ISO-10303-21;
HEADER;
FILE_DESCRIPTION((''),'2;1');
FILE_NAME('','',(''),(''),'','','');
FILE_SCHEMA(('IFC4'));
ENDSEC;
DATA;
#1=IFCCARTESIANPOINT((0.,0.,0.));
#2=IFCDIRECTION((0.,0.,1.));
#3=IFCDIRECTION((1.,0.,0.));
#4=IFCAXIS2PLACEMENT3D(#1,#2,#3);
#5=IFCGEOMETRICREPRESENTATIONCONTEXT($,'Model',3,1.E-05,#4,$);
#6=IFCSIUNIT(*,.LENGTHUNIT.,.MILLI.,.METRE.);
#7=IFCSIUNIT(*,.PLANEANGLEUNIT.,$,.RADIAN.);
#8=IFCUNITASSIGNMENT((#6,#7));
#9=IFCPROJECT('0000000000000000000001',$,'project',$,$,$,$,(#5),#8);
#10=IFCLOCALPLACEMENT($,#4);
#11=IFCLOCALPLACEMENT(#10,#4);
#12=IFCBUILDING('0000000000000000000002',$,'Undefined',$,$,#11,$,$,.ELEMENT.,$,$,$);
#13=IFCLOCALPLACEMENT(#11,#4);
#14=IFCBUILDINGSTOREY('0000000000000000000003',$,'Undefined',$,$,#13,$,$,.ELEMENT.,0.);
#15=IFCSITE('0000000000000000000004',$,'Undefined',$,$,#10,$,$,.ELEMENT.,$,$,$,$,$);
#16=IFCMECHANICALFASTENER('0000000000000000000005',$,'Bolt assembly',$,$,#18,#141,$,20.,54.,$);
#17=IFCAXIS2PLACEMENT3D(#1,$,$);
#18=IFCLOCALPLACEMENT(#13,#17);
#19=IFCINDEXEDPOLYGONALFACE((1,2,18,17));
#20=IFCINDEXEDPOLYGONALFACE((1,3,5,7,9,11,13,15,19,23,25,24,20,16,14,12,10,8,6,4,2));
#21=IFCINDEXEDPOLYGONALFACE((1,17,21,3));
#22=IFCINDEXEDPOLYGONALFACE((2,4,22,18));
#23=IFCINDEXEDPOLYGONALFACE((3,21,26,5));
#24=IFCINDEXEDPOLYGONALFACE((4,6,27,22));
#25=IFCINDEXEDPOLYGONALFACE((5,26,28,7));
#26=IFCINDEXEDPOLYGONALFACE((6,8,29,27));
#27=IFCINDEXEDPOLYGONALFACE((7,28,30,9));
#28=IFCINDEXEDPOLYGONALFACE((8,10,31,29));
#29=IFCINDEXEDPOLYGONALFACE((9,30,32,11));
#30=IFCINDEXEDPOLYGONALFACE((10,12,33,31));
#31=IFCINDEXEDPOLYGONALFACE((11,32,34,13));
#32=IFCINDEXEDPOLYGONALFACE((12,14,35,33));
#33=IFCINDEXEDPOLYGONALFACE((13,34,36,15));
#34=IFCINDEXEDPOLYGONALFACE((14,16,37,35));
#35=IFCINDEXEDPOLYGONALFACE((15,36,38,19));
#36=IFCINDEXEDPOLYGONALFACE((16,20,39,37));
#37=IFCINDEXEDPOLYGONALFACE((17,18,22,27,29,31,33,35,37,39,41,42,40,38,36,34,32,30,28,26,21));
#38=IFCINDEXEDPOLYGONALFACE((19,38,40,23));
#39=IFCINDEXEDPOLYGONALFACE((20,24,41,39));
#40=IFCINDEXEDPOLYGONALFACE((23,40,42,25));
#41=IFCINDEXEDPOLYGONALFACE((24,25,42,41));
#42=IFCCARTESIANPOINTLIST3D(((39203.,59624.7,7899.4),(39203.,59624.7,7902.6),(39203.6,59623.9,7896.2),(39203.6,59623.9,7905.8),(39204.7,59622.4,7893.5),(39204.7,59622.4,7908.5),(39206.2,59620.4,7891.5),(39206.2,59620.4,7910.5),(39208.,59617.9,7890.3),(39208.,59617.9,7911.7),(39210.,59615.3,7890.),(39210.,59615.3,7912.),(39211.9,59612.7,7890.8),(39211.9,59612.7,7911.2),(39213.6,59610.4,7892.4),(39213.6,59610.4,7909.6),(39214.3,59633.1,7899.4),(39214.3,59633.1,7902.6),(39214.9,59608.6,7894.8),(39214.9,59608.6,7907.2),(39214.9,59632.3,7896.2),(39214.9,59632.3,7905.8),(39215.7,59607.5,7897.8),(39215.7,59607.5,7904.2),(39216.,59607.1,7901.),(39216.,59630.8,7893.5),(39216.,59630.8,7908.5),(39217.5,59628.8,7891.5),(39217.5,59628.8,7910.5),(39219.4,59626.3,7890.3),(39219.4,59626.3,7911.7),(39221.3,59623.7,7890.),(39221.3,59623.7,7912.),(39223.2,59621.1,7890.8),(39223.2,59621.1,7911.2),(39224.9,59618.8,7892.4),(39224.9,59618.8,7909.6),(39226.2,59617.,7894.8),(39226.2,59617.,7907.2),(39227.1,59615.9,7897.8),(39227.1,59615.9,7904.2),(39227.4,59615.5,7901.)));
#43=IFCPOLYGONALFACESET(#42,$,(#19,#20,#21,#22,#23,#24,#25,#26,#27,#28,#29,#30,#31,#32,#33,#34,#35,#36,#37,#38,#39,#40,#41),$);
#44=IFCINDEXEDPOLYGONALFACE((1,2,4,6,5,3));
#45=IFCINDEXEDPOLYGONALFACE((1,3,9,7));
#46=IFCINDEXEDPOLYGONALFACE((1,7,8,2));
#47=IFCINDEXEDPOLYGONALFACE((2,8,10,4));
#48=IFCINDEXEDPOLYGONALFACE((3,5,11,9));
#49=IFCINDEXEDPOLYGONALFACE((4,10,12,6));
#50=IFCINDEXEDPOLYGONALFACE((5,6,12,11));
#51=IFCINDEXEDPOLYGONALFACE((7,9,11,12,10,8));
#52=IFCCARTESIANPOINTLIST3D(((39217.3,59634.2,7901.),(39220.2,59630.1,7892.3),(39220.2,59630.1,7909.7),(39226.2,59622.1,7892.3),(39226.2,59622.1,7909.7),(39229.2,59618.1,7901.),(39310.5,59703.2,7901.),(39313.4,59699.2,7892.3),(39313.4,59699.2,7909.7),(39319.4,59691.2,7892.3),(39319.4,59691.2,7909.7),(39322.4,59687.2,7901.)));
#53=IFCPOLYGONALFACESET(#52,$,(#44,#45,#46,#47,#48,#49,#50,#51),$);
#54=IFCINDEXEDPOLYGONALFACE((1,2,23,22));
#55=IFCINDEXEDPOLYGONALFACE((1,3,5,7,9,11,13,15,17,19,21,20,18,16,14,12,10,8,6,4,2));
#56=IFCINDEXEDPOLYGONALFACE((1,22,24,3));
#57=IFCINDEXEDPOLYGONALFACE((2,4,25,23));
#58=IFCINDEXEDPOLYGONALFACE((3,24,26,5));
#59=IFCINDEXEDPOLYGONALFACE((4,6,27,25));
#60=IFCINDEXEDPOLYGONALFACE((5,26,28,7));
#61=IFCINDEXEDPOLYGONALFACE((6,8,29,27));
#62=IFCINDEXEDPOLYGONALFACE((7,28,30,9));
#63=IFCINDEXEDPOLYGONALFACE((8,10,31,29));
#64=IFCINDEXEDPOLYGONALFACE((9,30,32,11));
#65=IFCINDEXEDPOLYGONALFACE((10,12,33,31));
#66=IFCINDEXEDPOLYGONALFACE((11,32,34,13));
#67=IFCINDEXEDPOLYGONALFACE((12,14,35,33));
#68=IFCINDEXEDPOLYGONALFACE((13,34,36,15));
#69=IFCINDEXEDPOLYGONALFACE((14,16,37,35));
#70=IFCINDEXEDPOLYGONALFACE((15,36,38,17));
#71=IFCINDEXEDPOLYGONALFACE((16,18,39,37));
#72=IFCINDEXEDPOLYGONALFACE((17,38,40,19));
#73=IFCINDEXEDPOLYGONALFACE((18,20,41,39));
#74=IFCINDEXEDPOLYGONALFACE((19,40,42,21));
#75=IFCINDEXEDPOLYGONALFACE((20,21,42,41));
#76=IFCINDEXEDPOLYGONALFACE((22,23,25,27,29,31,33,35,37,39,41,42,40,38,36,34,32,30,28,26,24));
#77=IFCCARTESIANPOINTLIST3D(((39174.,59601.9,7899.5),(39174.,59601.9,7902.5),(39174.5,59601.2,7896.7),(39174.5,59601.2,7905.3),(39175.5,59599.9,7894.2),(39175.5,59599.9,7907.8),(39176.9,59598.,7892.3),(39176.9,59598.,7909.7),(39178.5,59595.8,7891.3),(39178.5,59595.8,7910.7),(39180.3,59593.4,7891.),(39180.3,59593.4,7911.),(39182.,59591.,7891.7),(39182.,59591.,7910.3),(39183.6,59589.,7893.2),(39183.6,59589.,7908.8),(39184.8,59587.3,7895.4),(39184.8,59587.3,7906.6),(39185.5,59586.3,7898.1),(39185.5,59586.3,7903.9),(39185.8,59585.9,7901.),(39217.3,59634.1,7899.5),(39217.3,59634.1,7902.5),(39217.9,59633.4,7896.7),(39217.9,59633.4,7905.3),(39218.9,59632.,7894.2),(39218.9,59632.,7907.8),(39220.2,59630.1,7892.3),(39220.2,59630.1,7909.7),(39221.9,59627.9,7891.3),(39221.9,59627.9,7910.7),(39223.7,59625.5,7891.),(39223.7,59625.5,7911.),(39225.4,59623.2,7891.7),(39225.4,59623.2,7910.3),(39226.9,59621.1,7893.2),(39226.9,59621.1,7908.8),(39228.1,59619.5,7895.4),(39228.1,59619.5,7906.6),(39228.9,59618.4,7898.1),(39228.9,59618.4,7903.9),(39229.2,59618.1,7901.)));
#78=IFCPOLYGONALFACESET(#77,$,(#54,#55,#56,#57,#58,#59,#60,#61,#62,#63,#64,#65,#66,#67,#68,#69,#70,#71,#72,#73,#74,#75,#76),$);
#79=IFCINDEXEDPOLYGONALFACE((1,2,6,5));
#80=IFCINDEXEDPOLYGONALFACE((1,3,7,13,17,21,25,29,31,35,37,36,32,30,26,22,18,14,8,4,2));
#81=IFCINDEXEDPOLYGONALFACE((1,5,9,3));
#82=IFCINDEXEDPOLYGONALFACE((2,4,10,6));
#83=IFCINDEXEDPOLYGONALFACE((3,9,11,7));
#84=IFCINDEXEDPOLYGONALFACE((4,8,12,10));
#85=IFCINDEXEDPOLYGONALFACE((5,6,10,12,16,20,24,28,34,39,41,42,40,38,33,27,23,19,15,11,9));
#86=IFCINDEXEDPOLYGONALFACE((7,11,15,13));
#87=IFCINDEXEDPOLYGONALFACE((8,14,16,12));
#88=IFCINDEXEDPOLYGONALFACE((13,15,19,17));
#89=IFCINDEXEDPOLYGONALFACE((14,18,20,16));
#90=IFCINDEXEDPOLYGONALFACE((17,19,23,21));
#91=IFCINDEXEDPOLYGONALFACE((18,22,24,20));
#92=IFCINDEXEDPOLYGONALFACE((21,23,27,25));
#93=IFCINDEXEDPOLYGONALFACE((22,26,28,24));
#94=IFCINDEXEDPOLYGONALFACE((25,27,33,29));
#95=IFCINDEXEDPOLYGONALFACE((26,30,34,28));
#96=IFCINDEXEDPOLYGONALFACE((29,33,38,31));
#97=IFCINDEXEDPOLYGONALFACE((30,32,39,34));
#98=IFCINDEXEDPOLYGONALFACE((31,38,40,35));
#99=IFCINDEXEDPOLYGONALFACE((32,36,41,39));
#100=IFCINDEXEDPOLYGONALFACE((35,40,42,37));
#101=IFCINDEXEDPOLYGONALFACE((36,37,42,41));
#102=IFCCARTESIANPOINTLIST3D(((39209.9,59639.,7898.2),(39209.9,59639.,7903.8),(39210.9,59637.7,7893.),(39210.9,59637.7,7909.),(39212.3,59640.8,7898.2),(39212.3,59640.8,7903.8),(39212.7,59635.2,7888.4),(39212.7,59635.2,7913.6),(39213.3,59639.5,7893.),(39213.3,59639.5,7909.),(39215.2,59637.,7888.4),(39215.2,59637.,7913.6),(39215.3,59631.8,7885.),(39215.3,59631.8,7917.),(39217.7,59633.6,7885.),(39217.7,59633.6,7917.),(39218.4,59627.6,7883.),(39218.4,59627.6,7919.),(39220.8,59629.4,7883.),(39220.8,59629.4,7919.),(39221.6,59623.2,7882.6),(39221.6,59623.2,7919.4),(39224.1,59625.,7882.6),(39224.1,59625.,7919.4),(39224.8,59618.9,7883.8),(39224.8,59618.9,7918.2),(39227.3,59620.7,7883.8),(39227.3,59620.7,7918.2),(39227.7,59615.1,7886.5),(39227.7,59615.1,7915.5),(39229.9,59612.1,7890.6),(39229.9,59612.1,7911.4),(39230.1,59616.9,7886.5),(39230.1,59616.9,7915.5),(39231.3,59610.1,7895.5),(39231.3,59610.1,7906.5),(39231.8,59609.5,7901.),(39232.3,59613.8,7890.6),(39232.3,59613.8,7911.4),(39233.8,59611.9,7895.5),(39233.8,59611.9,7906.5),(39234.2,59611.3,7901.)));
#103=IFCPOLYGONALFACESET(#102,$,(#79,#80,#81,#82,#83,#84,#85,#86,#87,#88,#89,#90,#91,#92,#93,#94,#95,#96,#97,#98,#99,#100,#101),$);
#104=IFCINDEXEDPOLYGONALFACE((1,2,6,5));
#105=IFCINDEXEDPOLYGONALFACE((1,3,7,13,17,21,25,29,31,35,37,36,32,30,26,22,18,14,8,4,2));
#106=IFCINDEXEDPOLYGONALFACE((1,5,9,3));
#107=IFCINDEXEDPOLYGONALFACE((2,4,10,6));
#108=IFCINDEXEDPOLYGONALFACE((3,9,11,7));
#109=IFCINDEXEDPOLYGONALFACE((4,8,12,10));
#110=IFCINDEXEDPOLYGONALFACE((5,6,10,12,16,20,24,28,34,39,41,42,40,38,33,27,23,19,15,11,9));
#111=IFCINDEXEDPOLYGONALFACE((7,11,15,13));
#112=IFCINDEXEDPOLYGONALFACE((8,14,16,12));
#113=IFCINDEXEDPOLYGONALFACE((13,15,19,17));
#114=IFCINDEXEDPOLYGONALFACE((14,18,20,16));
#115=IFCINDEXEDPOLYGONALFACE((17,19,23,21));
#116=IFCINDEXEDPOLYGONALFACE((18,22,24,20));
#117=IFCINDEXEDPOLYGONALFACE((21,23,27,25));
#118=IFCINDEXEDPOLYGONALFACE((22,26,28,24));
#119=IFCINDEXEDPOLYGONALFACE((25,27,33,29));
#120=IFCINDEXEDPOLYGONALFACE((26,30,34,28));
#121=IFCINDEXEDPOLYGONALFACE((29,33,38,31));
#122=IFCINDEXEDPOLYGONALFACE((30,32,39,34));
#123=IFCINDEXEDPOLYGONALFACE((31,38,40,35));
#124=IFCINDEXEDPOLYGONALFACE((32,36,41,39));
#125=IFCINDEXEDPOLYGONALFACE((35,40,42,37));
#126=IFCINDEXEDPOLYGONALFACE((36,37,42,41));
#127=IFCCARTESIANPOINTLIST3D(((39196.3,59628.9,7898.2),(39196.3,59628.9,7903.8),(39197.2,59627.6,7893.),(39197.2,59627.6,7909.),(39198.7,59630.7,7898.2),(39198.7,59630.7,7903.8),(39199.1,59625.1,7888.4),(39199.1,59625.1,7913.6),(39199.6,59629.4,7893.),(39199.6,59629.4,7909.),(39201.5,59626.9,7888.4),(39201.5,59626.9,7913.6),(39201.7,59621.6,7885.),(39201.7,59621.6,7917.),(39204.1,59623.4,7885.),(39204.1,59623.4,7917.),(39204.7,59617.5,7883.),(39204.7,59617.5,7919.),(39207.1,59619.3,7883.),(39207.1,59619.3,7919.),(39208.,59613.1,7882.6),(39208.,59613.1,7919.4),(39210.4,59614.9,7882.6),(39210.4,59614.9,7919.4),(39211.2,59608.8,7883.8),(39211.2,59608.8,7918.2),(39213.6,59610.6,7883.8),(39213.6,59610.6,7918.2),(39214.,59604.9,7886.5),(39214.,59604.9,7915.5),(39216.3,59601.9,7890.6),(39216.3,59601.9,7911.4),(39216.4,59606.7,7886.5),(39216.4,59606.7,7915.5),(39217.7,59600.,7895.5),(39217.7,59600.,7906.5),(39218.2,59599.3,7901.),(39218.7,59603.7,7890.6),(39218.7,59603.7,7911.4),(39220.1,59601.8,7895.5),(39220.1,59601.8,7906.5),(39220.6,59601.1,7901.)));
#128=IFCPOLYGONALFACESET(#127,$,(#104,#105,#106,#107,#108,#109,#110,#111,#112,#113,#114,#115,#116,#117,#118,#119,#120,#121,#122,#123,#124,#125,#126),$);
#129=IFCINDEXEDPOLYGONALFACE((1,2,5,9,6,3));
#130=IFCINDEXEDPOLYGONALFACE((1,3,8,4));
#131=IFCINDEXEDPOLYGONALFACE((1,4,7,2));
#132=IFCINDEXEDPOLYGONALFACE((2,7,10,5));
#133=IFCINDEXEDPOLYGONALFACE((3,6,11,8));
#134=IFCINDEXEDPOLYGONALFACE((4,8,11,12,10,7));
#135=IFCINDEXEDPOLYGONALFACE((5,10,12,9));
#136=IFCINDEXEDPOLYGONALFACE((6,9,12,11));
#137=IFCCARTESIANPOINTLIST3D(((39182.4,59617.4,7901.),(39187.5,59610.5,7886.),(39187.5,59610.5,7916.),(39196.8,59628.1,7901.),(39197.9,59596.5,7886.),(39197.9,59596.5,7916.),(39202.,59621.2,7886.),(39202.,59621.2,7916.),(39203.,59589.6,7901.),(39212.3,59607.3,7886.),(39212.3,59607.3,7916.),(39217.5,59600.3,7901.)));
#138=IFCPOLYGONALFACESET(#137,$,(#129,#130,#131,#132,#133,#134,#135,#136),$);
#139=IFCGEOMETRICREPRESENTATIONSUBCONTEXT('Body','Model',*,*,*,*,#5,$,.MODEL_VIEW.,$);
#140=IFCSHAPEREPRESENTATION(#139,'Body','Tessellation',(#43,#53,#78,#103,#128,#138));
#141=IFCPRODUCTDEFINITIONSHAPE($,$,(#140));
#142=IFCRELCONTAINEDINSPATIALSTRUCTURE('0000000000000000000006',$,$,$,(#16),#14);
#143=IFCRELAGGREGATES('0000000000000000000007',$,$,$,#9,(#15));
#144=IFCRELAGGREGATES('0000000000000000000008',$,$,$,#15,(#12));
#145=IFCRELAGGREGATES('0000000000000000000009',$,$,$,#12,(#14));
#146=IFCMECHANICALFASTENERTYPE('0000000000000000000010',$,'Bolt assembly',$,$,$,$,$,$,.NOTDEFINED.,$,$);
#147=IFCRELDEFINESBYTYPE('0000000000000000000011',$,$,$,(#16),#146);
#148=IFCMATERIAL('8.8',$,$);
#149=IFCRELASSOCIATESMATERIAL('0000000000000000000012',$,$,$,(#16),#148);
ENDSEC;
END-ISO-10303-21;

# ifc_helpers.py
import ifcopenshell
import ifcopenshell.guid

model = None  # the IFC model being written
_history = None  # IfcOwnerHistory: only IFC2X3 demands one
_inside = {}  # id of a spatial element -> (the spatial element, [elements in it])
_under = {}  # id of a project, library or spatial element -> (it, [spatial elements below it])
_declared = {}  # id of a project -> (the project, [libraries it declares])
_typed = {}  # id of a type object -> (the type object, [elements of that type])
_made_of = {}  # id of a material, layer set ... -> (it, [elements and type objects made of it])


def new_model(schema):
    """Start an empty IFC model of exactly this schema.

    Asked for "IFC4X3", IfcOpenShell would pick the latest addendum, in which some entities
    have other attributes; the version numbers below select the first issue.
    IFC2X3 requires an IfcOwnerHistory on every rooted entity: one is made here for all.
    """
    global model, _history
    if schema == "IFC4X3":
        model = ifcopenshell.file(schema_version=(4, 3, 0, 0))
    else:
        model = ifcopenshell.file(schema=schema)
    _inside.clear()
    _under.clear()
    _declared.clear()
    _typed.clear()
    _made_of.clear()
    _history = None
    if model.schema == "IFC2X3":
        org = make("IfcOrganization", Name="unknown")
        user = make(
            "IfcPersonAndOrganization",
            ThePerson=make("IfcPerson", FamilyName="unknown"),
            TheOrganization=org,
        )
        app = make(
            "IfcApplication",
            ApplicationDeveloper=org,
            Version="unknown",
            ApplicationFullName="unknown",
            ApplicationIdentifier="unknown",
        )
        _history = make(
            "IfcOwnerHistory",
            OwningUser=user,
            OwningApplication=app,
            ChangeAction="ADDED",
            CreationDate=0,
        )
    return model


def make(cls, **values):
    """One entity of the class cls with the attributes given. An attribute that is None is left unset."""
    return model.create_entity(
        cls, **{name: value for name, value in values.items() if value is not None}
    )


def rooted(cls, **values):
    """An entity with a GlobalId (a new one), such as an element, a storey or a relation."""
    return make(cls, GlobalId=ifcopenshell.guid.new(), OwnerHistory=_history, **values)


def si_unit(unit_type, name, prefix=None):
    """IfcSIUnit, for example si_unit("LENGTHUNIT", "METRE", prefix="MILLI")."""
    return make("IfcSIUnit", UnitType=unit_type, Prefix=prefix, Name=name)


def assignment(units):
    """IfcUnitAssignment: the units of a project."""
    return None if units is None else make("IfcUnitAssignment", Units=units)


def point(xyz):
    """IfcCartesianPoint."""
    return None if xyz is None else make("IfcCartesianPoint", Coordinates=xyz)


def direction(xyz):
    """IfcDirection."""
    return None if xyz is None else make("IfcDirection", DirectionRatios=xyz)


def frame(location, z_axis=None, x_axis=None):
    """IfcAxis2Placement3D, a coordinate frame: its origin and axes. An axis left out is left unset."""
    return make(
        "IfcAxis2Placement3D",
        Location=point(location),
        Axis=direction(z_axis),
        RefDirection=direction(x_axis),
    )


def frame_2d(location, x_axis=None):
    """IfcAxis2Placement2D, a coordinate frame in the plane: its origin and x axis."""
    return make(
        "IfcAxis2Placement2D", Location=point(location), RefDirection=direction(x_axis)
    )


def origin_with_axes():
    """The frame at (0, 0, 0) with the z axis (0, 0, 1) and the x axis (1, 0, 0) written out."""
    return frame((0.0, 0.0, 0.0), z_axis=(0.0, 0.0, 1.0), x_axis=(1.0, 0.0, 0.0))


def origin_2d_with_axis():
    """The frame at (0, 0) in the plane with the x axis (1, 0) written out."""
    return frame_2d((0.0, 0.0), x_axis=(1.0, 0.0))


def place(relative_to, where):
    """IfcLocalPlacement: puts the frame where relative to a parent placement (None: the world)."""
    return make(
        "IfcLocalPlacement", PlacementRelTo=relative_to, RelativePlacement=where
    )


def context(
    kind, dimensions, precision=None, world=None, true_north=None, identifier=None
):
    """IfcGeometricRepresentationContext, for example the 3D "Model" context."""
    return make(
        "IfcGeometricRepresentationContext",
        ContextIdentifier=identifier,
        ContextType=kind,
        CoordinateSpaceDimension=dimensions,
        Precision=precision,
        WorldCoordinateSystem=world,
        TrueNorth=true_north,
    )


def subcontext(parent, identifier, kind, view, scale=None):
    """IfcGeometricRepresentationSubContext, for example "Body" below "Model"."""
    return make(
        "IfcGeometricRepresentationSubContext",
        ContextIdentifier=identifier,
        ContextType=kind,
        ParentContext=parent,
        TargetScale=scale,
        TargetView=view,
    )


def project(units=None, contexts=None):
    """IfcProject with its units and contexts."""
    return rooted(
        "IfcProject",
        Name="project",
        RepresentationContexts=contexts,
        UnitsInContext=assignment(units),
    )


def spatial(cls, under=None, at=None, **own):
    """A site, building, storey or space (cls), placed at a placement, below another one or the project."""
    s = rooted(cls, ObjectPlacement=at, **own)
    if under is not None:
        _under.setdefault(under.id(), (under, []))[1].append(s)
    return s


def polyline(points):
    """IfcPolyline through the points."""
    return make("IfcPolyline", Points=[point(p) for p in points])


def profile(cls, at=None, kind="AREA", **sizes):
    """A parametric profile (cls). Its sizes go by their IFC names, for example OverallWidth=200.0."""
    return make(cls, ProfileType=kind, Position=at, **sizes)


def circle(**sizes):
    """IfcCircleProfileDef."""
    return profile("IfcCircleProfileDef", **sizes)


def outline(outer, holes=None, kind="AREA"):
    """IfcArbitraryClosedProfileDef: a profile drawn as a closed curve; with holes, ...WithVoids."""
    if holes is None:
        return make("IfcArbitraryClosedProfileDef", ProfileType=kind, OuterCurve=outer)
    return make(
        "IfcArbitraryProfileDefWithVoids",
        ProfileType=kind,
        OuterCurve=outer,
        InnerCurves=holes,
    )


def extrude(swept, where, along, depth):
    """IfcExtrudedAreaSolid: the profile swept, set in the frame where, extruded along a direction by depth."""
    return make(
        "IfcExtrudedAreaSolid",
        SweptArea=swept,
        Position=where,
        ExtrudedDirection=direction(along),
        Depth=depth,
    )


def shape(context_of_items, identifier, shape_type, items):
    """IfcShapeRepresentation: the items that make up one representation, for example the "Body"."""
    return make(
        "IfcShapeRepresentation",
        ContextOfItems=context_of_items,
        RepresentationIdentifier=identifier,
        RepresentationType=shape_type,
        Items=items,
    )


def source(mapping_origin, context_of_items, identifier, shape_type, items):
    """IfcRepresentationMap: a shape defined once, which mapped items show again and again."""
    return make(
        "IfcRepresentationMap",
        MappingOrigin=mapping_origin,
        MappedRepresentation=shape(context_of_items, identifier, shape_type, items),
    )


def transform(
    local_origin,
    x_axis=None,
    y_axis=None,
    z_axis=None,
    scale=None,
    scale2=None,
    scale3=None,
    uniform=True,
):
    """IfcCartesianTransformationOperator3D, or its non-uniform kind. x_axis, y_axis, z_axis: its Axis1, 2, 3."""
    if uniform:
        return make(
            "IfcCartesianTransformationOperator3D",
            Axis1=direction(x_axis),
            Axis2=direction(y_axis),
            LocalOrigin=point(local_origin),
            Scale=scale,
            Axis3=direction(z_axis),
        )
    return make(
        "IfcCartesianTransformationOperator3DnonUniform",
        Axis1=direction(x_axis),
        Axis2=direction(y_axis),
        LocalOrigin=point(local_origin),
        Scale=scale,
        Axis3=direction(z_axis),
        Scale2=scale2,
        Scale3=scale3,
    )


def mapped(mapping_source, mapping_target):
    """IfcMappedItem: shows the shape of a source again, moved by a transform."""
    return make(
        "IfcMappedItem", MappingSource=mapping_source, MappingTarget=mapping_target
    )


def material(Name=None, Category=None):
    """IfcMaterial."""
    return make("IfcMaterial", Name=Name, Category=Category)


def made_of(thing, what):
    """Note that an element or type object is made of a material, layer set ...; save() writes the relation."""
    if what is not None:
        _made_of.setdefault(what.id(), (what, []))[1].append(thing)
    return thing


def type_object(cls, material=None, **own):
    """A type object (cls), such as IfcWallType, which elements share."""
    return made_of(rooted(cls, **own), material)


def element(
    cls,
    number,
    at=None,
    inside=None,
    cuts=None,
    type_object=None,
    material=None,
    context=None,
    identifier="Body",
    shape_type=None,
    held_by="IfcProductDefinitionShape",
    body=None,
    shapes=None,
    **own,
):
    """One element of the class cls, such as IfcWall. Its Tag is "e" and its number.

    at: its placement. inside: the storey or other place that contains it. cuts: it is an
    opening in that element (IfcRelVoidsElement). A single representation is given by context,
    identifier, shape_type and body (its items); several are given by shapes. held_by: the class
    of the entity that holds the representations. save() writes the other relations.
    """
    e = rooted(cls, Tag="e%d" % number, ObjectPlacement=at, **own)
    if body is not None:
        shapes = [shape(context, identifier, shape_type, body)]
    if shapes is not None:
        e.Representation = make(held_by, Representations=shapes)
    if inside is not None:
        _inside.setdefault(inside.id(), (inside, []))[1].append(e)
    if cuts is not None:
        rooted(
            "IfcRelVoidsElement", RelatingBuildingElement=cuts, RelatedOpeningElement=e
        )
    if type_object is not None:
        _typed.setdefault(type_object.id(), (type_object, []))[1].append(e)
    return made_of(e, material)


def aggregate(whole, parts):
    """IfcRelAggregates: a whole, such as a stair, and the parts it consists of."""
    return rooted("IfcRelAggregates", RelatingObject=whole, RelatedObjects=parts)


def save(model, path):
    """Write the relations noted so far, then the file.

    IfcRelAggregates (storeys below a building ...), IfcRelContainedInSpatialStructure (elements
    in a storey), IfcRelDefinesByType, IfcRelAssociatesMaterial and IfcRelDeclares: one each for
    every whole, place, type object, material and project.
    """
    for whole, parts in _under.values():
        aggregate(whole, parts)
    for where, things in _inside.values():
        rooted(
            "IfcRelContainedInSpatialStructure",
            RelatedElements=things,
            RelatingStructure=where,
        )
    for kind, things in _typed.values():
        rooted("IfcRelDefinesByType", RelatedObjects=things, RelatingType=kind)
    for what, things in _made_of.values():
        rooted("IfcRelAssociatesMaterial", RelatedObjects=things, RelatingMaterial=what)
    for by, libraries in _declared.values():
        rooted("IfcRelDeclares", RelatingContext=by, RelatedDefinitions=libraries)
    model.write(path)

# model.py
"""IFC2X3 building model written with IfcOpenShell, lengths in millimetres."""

from ifc_helpers import new_model, si_unit, frame, origin_with_axes, origin_2d_with_axis, place, context, subcontext, project, spatial, polyline, circle, outline, extrude, source, transform, mapped, material, type_object, element, save


model = new_model("IFC2X3")

# Units and contexts
model_context = context("Model", 3, precision=1e-05, world=origin_with_axes())
body_context = subcontext(model_context, "Body", "Model", "MODEL_VIEW")
ifc_project = project(units=[si_unit("LENGTHUNIT", "METRE", prefix="MILLI"), si_unit("PLANEANGLEUNIT", "RADIAN")], contexts=[model_context])

# Site, building, storey
site_placement = place(None, origin_with_axes())
site = spatial("IfcSite", under=ifc_project, at=site_placement, Name="Undefined", CompositionType="ELEMENT")
building_placement = place(site_placement, origin_with_axes())
building = spatial("IfcBuilding", under=site, at=building_placement, Name="Undefined", CompositionType="ELEMENT")
storey_placement = place(building_placement, origin_with_axes())
storey = spatial("IfcBuildingStorey", under=building, at=storey_placement, Name="Undefined", CompositionType="ELEMENT", Elevation=0.0)

# Mechanical fastener
ifc_material_1 = material(Name="8.8")
mechanical_fastener_type = type_object("IfcMechanicalFastenerType", Name="Bolt assembly")
shared_shape_1 = source(origin_with_axes(), body_context, "Body", "SweptSolid", [
    extrude(circle(Radius=11.0, at=origin_2d_with_axis()), frame((0.0, -14.0, 0.0), z_axis=(0.0, 1.0, 0.0), x_axis=(1.0, 0.0, 0.0)), (0.0, 0.0, 1.0), 14.1),
    extrude(outline(polyline([(10.0, 0.0), (5.0, 8.7), (-5.0, 8.7), (-10.0, 0.0), (-5.0, -8.7), (5.0, -8.7), (10.0, 0.0)])), frame((0.0, -133.0, 0.0), z_axis=(0.0, 1.0, 0.0), x_axis=(1.0, 0.0, 0.0)), (0.0, 0.0, 1.0), 116.0),
    extrude(circle(Radius=10.0, at=origin_2d_with_axis()), frame((0.0, -17.0, 0.0), z_axis=(0.0, 1.0, 0.0), x_axis=(1.0, 0.0, 0.0)), (0.0, 0.0, 1.0), 54.0),
    extrude(circle(Radius=18.5, at=origin_2d_with_axis()), frame((0.0, -17.0, 0.0), z_axis=(0.0, 1.0, 0.0), x_axis=(1.0, 0.0, 0.0)), (0.0, 0.0, 1.0), 3.0),
    extrude(circle(Radius=18.5, at=origin_2d_with_axis()), frame((0.0, 0.0, 0.0), z_axis=(0.0, 1.0, 0.0), x_axis=(1.0, 0.0, 0.0)), (0.0, 0.0, 1.0), 3.0),
    extrude(outline(polyline([(17.3, 0.0), (8.7, 15.0), (-8.7, 15.0), (-17.3, 0.0), (-8.7, -15.0), (8.7, -15.0), (17.3, 0.0)])), frame((0.0, 3.0, 0.0), z_axis=(0.0, 1.0, 0.0), x_axis=(1.0, 0.0, 0.0)), (0.0, 0.0, 1.0), 18.0),
])
mechanical_fastener_1_placement = place(storey_placement, frame((39209.6, 59616.0, 7901.0), z_axis=(0.0, 0.0, -1.0), x_axis=(0.595471, -0.803377, 0.0)))
element("IfcMechanicalFastener", 1, at=mechanical_fastener_1_placement, inside=storey, type_object=mechanical_fastener_type, material=ifc_material_1, Name="Bolt assembly", NominalDiameter=20.0, NominalLength=54.0, context=body_context, shape_type="MappedRepresentation", body=[
    mapped(shared_shape_1, transform((0.0, 0.0, 0.0))),
])

save(model, "model.ifc")
